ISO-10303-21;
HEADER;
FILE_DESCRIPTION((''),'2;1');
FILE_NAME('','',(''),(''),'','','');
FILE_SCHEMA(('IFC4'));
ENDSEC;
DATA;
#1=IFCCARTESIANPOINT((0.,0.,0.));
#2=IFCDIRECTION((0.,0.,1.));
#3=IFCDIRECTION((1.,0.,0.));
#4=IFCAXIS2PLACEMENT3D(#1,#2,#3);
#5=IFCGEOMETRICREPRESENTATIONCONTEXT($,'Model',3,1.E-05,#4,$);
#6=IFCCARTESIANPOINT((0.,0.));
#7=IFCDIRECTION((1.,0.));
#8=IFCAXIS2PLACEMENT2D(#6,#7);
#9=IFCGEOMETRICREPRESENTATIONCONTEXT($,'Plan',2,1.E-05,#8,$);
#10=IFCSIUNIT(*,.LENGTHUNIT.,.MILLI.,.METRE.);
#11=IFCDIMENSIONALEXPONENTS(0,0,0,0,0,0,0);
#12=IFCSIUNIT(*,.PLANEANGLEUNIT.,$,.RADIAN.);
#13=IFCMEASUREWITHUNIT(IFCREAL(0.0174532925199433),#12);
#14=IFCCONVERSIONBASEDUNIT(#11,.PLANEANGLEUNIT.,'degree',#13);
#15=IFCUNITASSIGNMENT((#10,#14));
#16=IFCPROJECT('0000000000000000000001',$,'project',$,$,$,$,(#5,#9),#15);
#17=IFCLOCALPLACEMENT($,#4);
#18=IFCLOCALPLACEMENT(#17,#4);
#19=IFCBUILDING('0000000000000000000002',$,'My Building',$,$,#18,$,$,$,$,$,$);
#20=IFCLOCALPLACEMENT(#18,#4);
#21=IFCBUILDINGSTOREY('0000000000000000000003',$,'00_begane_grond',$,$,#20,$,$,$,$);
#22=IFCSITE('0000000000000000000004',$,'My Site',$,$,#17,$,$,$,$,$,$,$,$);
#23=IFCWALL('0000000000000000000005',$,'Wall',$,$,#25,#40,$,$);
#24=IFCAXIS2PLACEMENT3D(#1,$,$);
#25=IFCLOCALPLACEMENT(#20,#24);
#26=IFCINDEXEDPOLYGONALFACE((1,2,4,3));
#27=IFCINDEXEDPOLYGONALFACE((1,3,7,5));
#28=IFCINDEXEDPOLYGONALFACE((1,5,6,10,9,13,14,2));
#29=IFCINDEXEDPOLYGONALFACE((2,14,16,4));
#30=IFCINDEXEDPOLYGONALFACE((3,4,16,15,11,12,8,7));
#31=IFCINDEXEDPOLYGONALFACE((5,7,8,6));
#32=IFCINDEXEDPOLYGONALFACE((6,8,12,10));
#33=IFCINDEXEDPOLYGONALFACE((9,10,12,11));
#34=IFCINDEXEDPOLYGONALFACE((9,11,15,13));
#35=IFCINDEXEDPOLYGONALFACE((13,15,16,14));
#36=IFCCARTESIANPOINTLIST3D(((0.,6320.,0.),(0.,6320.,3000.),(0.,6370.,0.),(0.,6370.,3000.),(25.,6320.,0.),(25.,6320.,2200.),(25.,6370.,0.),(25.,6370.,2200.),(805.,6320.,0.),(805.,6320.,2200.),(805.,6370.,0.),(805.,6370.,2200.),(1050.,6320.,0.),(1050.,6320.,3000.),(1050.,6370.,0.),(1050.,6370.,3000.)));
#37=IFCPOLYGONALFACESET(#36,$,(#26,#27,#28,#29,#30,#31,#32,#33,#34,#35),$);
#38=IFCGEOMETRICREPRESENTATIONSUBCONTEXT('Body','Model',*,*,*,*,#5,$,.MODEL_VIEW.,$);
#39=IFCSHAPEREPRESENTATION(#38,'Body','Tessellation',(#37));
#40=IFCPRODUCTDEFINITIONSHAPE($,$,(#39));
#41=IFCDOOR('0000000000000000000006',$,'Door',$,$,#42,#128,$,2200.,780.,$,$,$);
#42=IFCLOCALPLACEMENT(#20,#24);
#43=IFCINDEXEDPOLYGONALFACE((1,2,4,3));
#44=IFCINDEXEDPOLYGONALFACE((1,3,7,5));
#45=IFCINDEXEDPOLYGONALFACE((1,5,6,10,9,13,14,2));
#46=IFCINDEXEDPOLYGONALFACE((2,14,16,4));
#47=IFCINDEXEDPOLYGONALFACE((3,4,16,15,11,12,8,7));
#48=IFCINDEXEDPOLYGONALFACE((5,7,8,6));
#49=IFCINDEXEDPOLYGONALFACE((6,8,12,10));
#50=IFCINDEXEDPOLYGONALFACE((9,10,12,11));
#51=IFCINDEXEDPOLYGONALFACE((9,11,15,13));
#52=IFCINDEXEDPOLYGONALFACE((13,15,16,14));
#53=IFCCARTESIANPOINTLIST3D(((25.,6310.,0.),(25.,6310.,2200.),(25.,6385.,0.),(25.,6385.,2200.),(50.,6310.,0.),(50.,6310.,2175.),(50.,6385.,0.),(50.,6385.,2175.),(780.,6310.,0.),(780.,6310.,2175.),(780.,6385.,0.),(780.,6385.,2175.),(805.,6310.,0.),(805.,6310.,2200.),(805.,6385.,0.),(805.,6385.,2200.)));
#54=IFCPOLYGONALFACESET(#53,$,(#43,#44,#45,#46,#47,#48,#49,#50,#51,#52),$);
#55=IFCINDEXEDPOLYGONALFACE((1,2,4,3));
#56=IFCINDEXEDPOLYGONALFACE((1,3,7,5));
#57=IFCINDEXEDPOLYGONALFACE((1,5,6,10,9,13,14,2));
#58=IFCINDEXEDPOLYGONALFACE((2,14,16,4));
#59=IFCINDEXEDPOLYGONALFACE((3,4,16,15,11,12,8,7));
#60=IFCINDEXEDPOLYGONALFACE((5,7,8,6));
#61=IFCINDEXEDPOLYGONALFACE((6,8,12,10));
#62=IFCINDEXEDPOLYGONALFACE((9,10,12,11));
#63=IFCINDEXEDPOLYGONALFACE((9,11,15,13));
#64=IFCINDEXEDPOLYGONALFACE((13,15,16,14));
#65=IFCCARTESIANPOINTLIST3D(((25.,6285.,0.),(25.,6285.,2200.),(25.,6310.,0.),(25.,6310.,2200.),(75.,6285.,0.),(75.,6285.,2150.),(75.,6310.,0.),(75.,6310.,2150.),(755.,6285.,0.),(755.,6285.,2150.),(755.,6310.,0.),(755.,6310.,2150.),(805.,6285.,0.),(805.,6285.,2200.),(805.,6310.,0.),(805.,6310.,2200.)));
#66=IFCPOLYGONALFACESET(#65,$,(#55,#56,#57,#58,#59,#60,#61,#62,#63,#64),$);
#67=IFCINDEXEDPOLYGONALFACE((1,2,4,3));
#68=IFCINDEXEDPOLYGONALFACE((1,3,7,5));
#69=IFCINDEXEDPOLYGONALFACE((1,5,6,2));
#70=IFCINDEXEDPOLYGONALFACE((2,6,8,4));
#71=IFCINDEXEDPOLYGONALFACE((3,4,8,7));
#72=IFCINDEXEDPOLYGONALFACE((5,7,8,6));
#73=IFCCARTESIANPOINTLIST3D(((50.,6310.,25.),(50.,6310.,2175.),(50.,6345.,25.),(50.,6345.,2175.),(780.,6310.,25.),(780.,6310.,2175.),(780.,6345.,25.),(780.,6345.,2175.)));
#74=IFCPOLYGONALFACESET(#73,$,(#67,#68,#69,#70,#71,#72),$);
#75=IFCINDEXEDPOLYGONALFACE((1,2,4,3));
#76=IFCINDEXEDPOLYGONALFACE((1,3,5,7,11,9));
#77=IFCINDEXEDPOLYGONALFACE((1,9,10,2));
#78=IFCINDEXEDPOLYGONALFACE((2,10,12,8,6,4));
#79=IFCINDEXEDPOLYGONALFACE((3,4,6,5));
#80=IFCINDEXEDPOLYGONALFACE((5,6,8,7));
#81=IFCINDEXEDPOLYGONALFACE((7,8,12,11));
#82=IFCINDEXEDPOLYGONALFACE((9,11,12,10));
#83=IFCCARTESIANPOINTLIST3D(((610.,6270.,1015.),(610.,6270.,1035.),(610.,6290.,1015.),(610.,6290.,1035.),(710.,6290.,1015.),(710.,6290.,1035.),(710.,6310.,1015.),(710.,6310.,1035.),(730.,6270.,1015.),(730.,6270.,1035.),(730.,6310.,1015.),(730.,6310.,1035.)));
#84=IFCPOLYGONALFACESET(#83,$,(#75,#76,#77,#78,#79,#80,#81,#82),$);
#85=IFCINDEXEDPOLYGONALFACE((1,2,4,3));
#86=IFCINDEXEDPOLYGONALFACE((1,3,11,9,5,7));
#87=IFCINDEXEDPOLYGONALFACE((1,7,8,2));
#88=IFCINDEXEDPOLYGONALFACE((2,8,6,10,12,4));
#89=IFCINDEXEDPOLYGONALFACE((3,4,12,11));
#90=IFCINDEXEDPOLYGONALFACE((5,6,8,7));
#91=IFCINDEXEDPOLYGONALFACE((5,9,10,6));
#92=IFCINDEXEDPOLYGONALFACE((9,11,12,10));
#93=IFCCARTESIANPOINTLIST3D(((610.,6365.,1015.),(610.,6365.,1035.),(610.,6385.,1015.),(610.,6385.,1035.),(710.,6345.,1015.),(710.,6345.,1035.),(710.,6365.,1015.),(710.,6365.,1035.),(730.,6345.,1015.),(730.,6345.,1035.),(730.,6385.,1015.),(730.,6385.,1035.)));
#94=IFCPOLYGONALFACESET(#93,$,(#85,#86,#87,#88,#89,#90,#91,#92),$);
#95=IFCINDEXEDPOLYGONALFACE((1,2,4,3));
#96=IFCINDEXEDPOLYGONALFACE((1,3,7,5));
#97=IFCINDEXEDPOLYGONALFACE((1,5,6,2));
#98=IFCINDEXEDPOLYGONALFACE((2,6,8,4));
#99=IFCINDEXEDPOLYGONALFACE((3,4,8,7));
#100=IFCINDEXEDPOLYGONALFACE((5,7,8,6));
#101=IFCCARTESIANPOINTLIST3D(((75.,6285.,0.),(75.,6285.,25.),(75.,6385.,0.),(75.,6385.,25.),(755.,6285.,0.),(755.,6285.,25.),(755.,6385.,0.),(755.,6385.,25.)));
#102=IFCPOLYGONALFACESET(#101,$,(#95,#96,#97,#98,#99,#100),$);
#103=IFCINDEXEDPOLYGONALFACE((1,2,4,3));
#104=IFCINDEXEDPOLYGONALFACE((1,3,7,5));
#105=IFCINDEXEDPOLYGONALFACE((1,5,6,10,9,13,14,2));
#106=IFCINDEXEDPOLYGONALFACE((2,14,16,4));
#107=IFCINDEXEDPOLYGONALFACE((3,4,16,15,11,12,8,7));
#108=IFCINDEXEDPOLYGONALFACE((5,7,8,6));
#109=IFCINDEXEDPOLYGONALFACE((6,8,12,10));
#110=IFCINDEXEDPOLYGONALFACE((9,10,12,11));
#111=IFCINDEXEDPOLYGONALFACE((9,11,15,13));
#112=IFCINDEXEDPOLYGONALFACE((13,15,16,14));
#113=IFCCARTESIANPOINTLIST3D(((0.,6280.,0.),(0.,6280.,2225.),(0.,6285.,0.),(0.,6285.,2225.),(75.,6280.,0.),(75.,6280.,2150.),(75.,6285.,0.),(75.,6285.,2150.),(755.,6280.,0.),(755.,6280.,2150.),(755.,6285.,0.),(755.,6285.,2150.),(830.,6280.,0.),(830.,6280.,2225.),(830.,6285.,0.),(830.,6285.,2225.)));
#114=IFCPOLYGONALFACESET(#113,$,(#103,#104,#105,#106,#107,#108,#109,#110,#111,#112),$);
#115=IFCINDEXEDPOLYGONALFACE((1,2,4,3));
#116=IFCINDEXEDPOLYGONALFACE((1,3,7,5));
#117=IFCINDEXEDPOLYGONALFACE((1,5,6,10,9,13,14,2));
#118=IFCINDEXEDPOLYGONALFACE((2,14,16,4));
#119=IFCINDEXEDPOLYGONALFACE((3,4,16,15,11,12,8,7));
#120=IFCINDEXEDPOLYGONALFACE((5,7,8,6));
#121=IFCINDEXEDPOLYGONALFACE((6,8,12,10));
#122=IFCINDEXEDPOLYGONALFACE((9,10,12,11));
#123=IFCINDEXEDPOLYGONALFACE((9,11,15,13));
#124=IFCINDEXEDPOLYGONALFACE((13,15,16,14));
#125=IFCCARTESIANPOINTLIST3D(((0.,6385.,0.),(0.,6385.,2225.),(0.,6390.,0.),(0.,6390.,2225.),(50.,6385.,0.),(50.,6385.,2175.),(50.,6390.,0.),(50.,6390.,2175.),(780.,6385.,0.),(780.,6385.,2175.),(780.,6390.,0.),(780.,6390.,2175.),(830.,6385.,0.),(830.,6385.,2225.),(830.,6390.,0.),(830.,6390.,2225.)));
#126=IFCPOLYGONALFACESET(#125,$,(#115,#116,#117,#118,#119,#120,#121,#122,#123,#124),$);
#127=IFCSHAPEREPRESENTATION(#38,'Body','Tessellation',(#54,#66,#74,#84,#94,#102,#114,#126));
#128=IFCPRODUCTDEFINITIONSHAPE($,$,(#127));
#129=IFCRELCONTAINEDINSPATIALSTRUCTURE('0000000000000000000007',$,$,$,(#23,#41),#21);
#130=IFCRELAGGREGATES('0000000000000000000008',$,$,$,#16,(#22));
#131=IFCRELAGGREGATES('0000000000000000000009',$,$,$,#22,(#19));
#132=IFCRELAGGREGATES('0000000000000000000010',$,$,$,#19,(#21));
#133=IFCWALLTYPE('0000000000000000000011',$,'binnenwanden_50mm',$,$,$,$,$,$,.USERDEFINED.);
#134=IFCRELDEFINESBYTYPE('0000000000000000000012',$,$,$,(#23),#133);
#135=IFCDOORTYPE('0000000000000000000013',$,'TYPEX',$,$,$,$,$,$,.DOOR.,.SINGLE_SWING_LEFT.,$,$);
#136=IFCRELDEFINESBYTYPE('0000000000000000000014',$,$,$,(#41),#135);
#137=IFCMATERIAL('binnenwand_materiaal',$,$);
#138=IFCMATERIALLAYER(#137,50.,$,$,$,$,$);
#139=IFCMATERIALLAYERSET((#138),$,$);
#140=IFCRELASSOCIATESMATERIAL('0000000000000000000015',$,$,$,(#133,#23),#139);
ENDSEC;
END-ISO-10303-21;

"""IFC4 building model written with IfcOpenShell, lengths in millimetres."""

from ifc_helpers import new_model, entity, si_unit, converted_unit, frame, origin_with_axes, origin_2d_with_axis, place, context, subcontext, project, spatial, line, indexed_curve, outline, extrude, shape, source, transform, mapped, material, layer, layer_set, layer_usage, type_object, type_shapes, element, fill, save


model = new_model("IFC4")

# Units and contexts
model_context = context("Model", 3, precision=1e-05, world=origin_with_axes())
plan_context = context("Plan", 2, precision=1e-05, world=origin_2d_with_axis())
body_context_1 = subcontext(model_context, "Body", "Model", "MODEL_VIEW")
body_context_2 = subcontext(plan_context, "Body", "Plan", "PLAN_VIEW")
ifc_project = project(units=[si_unit("LENGTHUNIT", "METRE", prefix="MILLI"), converted_unit("PLANEANGLEUNIT", "degree", entity("IfcReal", 0.0174532925199433), si_unit("PLANEANGLEUNIT", "RADIAN"), dimensions=[0, 0, 0, 0, 0, 0, 0])], contexts=[model_context, plan_context])

# Site, building, storey
site_placement = place(None, origin_with_axes())
site = spatial("IfcSite", under=ifc_project, at=site_placement, Name="My Site")
building_placement = place(site_placement, origin_with_axes())
building = spatial("IfcBuilding", under=site, at=building_placement, Name="My Building")
storey_placement = place(building_placement, origin_with_axes())
storey = spatial("IfcBuildingStorey", under=building, at=storey_placement, Name="00_begane_grond")

# Shared definitions
shared_shape_1 = source(origin_with_axes(), body_context_1, "Body", "SweptSolid", [
    extrude(outline(indexed_curve([(0.0, 0.0), (780.0, 0.0), (780.0, 2200.0), (0.0, 2200.0)], segments=[line(1, 2, 3, 4, 1)])), frame((0.0, -100.0, 0.0), z_axis=(0.0, -1.0, 0.0), x_axis=(1.0, 0.0, 0.0)), (0.0, 0.0, -1.0), 300.0),
])
door_type = type_object("IfcDoorType", Name="TYPEX", OperationType="SINGLE_SWING_LEFT", PredefinedType="DOOR")
shared_shape_2 = source(origin_with_axes(), body_context_1, "Body", "SweptSolid", [
    extrude(outline(indexed_curve([(0.0, 0.0), (0.0, 2200.0), (780.0, 2200.0), (780.0, 0.0), (755.0, 0.0), (755.0, 2175.0), (25.0, 2175.0), (25.0, 0.0)], segments=[line(1, 2, 3, 4, 5, 6, 7, 8, 1)])), frame((0.0, 25.0, 0.0), z_axis=(0.0, -1.0, 0.0), x_axis=(1.0, 0.0, 0.0)), (0.0, 0.0, -1.0), 75.0),
    extrude(outline(indexed_curve([(0.0, 0.0), (0.0, 2200.0), (780.0, 2200.0), (780.0, 0.0), (730.0, 0.0), (730.0, 2150.0), (50.0, 2150.0), (50.0, 0.0)], segments=[line(1, 2, 3, 4, 5, 6, 7, 8, 1)])), frame((0.0, 0.0, 0.0), z_axis=(0.0, -1.0, 0.0), x_axis=(1.0, 0.0, 0.0)), (0.0, 0.0, -1.0), 25.0),
    extrude(outline(indexed_curve([(0.0, 0.0), (730.0, 0.0), (730.0, 35.0), (0.0, 35.0)], segments=[line(1, 2, 3, 4, 1)])), frame((25.0, 25.0, 25.0), z_axis=(0.0, 0.0, 1.0), x_axis=(1.0, 0.0, 0.0)), (0.0, 0.0, 1.0), 2150.0),
    extrude(outline(indexed_curve([(0.0, 0.0), (0.0, -40.0), (-120.0, -40.0), (-120.0, -20.0), (-20.0, -20.0), (-20.0, 0.0)], segments=[line(1, 2, 3, 4, 5, 6, 1)])), frame((705.0, 25.0, 1015.0), z_axis=(0.0, 0.0, 1.0), x_axis=(1.0, 0.0, 0.0)), (0.0, 0.0, 1.0), 20.0),
    extrude(outline(indexed_curve([(0.0, 0.0), (0.0, 40.0), (-120.0, 40.0), (-120.0, 20.0), (-20.0, 20.0), (-20.0, 0.0)], segments=[line(1, 2, 3, 4, 5, 6, 1)])), frame((705.0, 60.0, 1015.0), z_axis=(0.0, 0.0, 1.0), x_axis=(1.0, 0.0, 0.0)), (0.0, 0.0, 1.0), 20.0),
    extrude(outline(indexed_curve([(0.0, 0.0), (680.0, 0.0), (680.0, 100.0), (0.0, 100.0)], segments=[line(1, 2, 3, 4, 1)])), frame((50.0, 0.0, 0.0), z_axis=(0.0, 0.0, 1.0), x_axis=(1.0, 0.0, 0.0)), (0.0, 0.0, 1.0), 25.0),
    extrude(outline(indexed_curve([(0.0, 0.0), (0.0, 2225.0), (830.0, 2225.0), (830.0, 0.0), (755.0, 0.0), (755.0, 2150.0), (75.0, 2150.0), (75.0, 0.0)], segments=[line(1, 2, 3, 4, 5, 6, 7, 8, 1)])), frame((-25.0, -5.0, 0.0), z_axis=(0.0, -1.0, 0.0), x_axis=(1.0, 0.0, 0.0)), (0.0, 0.0, -1.0), 5.0),
    extrude(outline(indexed_curve([(0.0, 0.0), (0.0, 2225.0), (830.0, 2225.0), (830.0, 0.0), (780.0, 0.0), (780.0, 2175.0), (50.0, 2175.0), (50.0, 0.0)], segments=[line(1, 2, 3, 4, 5, 6, 7, 8, 1)])), frame((-25.0, 100.0, 0.0), z_axis=(0.0, -1.0, 0.0), x_axis=(1.0, 0.0, 0.0)), (0.0, 0.0, -1.0), 5.0),
])
shared_shape_3 = source(origin_with_axes(), body_context_2, "Body", "Curve2D", [
    entity("IfcIndexedPolyCurve", entity("IfcCartesianPointList2D", [[0.0, 0.0], [0.0, 100.0], [25.0, 100.0], [25.0, 25.0], [50.0, 25.0], [50.0, 0.0]]), [entity("IfcLineIndex", [1, 2, 3, 4, 5, 6, 1])]),
    entity("IfcIndexedPolyCurve", entity("IfcCartesianPointList2D", [[780.0, 0.0], [780.0, 100.0], [755.0, 100.0], [755.0, 25.0], [730.0, 25.0], [730.0, 0.0]]), [entity("IfcLineIndex", [1, 2, 3, 4, 5, 6, 1])]),
    entity("IfcTrimmedCurve", entity("IfcEllipse", entity("IfcAxis2Placement2D", entity("IfcCartesianPoint", [60.0, 100.0]), entity("IfcDirection", [1.0, 0.0])), 695.0, 730.0), [entity("IfcCartesianPoint", [755.0, 100.0])], [entity("IfcCartesianPoint", [60.0, 830.0])], True, "CARTESIAN"),
    entity("IfcIndexedPolyCurve", entity("IfcCartesianPointList2D", [[25.0, 100.0], [60.0, 100.0], [60.0, 830.0], [25.0, 830.0]]), [entity("IfcLineIndex", [1, 2, 3, 4, 1])]),
])
type_shapes(door_type, [shared_shape_2, shared_shape_3])

# Shared definitions
ifc_material_1 = material(Name="binnenwand_materiaal")
ifc_layer_1 = layer(ifc_material_1, 50.0)
ifc_layer_set_1 = layer_set([ifc_layer_1])
wall_type_1 = type_object("IfcWallType", Name="binnenwanden_50mm", PredefinedType="USERDEFINED", material=ifc_layer_set_1)

# Wall, opening, door
ifc_layer_usage_1 = layer_usage(ifc_layer_set_1, "AXIS2", "POSITIVE", 0.0)
wall_1_placement = place(storey_placement, frame((1050.0, 6370.0, 0.0), z_axis=(0.0, 0.0, 1.0), x_axis=(-1.0, 0.0, 0.0)))
wall_1 = element("IfcWall", 1, at=wall_1_placement, inside=storey, type_object=wall_type_1, material=ifc_layer_usage_1, Name="Wall", context=body_context_1, shape_type="SweptSolid", body=[
    extrude(outline(indexed_curve([(0.0, 0.0), (0.0, 50.0), (1050.0, 50.0), (1050.0, 0.0), (0.0, 0.0)], self_intersect=False)), origin_with_axes(), (0.0, 0.0, 1.0), 3000.0),
])
opening_1_placement = place(wall_1_placement, frame((1025.0, 85.0, 0.0), z_axis=(0.0, 0.0, 1.0), x_axis=(-1.0, 0.0, 0.0)))
opening_1 = element("IfcOpeningElement", 2, at=opening_1_placement, cuts=wall_1, PredefinedType="OPENING", context=body_context_1, shape_type="MappedRepresentation", body=[
    mapped(shared_shape_1, transform((0.0, 0.0, 0.0), x_axis=(1.0, 0.0, 0.0), y_axis=(0.0, 1.0, 0.0), z_axis=(0.0, 0.0, 1.0), scale=1.0)),
])
door_1_placement = place(opening_1_placement, frame((0.0, 0.0, 0.0), z_axis=(0.0, 0.0, 1.0), x_axis=(1.0, 0.0, 0.0)))
door_1 = element("IfcDoor", 3, at=door_1_placement, inside=storey, type_object=door_type, Name="Door", OverallHeight=2200.0, OverallWidth=780.0, shapes=[
    shape(body_context_1, "Body", "MappedRepresentation", [mapped(shared_shape_2, transform((0.0, 0.0, 0.0), x_axis=(1.0, 0.0, 0.0), y_axis=(0.0, 1.0, 0.0), z_axis=(0.0, 0.0, 1.0), scale=1.0))]),
    shape(body_context_2, "Body", "MappedRepresentation", [mapped(shared_shape_3, transform((0.0, 0.0, 0.0), x_axis=(1.0, 0.0, 0.0), y_axis=(0.0, 1.0, 0.0), z_axis=(0.0, 0.0, 1.0), scale=1.0))]),
])
fill(opening_1, door_1)

save(model, "model.ifc")
